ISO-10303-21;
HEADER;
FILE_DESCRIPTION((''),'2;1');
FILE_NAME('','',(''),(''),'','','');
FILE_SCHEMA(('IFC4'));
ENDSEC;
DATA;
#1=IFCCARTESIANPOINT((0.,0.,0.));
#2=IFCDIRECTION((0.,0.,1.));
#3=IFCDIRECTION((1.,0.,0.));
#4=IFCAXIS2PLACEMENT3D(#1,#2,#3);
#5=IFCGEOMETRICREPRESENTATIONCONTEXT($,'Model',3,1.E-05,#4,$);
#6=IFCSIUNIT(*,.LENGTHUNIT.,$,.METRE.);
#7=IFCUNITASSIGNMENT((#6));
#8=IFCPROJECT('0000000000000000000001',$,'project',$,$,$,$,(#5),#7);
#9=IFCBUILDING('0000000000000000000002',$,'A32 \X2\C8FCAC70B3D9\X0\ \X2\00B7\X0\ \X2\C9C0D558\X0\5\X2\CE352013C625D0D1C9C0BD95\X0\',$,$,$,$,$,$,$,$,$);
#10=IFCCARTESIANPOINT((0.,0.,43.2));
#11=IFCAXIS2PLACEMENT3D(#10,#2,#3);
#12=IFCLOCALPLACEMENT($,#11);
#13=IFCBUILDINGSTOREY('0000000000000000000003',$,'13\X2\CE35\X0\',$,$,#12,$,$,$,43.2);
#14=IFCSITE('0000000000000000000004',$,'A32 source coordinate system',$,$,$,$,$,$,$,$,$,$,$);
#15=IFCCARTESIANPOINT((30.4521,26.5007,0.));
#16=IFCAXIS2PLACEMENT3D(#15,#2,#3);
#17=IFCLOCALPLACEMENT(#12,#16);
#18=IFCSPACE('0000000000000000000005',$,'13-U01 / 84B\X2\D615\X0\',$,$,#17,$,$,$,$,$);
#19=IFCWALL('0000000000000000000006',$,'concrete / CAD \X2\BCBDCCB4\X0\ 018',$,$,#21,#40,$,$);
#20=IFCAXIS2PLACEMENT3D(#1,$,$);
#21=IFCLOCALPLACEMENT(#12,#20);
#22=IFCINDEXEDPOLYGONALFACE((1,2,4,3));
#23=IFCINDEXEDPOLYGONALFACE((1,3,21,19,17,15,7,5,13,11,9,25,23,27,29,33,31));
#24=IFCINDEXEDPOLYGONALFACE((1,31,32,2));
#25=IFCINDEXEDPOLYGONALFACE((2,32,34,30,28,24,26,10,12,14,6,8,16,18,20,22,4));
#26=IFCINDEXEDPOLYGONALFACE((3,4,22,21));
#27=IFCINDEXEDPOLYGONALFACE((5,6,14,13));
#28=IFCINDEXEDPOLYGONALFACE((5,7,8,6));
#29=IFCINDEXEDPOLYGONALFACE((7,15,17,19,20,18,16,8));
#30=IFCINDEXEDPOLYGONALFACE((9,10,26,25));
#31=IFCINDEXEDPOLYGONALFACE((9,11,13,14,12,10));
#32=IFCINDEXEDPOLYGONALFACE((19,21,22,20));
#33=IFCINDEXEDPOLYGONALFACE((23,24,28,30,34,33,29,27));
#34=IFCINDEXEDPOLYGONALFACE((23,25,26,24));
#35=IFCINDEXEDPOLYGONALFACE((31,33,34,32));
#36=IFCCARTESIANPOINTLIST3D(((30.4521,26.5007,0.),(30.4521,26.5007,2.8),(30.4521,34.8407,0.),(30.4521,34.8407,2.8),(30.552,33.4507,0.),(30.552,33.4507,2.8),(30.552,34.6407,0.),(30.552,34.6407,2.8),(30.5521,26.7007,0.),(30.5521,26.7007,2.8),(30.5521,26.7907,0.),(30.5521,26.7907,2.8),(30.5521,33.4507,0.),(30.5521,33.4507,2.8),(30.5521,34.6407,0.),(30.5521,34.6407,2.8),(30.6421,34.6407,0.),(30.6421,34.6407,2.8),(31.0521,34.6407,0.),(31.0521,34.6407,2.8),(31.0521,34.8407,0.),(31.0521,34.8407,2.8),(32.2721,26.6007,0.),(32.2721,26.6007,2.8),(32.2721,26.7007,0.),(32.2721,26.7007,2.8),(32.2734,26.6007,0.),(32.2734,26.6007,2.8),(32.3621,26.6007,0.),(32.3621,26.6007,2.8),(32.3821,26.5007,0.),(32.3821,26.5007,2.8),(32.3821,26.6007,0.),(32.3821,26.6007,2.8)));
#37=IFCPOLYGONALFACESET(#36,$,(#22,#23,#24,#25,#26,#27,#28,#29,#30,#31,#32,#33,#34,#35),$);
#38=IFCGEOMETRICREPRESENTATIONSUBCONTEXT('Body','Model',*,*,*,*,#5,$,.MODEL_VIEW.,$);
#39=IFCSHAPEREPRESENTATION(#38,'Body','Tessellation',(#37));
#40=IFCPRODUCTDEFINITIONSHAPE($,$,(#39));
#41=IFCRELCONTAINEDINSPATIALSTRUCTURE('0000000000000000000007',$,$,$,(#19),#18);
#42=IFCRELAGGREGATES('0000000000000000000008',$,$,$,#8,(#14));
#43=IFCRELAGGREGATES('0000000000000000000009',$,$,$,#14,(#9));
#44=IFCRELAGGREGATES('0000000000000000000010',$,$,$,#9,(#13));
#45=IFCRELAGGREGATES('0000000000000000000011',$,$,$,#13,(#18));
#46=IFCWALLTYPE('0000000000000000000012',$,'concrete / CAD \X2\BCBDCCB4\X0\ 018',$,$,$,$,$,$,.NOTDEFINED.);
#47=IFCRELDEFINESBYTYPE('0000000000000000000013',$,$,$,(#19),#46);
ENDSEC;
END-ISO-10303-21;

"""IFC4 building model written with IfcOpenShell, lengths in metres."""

from ifc_helpers import new_model, si_unit, frame, origin, origin_with_axes, place, context, subcontext, project, spatial, polyline, outline, extrude, source, transform, mapped, type_object, type_shapes, element, save


model = new_model("IFC4")

# Units and contexts
model_context = context("Model", 3, precision=1e-05, world=origin_with_axes())
body_context = subcontext(model_context, "Body", "Model", "MODEL_VIEW")
ifc_project = project(units=[si_unit("LENGTHUNIT", "METRE")], contexts=[model_context])

# Site, building, storey, space
site = spatial("IfcSite", under=ifc_project, Name="A32 source coordinate system")
building = spatial("IfcBuilding", under=site, Name="A32 주거동 · 지하5층–옥탑지붕")
storey_placement = place(None, frame((0.0, 0.0, 43.2), z_axis=(0.0, 0.0, 1.0), x_axis=(1.0, 0.0, 0.0)))
storey = spatial("IfcBuildingStorey", under=building, at=storey_placement, Name="13층", Elevation=43.2)
space_1_placement = place(storey_placement, frame((30.4521, 26.5007, 0.0), z_axis=(0.0, 0.0, 1.0), x_axis=(1.0, 0.0, 0.0)))
space_1 = spatial("IfcSpace", under=storey, at=space_1_placement, Name="13-U01 / 84B형")

# Wall
wall_type_1 = type_object("IfcWallType", Name="concrete / CAD 벽체 018", PredefinedType="NOTDEFINED")
shared_shape_1 = source(origin(), body_context, "Body", "SweptSolid", [
    extrude(outline(polyline([(0.6, 8.34), (0.6, 8.14), (0.19, 8.14), (0.1, 8.14), (0.0999, 8.14), (0.0999, 6.95), (0.1, 6.95), (0.1, 0.29), (0.1, 0.2), (1.82, 0.2), (1.82, 0.1), (1.8213, 0.1), (1.91, 0.1), (1.93, 0.1), (1.93, 0.0), (0.0, 0.0), (0.0, 8.34), (-0.35, 8.34), (-0.35, 8.34), (0.6, 8.34)])), origin(), (0.0, 0.0, 1.0), 2.8),
])
type_shapes(wall_type_1, [shared_shape_1])
wall_1_placement = place(space_1_placement, origin_with_axes())
element("IfcWall", 1, at=wall_1_placement, inside=space_1, type_object=wall_type_1, Name="concrete / CAD 벽체 018", context=body_context, shape_type="MappedRepresentation", body=[
    mapped(shared_shape_1, transform((0.0, 0.0, 0.0), scale=1.0)),
])

save(model, "model.ifc")
